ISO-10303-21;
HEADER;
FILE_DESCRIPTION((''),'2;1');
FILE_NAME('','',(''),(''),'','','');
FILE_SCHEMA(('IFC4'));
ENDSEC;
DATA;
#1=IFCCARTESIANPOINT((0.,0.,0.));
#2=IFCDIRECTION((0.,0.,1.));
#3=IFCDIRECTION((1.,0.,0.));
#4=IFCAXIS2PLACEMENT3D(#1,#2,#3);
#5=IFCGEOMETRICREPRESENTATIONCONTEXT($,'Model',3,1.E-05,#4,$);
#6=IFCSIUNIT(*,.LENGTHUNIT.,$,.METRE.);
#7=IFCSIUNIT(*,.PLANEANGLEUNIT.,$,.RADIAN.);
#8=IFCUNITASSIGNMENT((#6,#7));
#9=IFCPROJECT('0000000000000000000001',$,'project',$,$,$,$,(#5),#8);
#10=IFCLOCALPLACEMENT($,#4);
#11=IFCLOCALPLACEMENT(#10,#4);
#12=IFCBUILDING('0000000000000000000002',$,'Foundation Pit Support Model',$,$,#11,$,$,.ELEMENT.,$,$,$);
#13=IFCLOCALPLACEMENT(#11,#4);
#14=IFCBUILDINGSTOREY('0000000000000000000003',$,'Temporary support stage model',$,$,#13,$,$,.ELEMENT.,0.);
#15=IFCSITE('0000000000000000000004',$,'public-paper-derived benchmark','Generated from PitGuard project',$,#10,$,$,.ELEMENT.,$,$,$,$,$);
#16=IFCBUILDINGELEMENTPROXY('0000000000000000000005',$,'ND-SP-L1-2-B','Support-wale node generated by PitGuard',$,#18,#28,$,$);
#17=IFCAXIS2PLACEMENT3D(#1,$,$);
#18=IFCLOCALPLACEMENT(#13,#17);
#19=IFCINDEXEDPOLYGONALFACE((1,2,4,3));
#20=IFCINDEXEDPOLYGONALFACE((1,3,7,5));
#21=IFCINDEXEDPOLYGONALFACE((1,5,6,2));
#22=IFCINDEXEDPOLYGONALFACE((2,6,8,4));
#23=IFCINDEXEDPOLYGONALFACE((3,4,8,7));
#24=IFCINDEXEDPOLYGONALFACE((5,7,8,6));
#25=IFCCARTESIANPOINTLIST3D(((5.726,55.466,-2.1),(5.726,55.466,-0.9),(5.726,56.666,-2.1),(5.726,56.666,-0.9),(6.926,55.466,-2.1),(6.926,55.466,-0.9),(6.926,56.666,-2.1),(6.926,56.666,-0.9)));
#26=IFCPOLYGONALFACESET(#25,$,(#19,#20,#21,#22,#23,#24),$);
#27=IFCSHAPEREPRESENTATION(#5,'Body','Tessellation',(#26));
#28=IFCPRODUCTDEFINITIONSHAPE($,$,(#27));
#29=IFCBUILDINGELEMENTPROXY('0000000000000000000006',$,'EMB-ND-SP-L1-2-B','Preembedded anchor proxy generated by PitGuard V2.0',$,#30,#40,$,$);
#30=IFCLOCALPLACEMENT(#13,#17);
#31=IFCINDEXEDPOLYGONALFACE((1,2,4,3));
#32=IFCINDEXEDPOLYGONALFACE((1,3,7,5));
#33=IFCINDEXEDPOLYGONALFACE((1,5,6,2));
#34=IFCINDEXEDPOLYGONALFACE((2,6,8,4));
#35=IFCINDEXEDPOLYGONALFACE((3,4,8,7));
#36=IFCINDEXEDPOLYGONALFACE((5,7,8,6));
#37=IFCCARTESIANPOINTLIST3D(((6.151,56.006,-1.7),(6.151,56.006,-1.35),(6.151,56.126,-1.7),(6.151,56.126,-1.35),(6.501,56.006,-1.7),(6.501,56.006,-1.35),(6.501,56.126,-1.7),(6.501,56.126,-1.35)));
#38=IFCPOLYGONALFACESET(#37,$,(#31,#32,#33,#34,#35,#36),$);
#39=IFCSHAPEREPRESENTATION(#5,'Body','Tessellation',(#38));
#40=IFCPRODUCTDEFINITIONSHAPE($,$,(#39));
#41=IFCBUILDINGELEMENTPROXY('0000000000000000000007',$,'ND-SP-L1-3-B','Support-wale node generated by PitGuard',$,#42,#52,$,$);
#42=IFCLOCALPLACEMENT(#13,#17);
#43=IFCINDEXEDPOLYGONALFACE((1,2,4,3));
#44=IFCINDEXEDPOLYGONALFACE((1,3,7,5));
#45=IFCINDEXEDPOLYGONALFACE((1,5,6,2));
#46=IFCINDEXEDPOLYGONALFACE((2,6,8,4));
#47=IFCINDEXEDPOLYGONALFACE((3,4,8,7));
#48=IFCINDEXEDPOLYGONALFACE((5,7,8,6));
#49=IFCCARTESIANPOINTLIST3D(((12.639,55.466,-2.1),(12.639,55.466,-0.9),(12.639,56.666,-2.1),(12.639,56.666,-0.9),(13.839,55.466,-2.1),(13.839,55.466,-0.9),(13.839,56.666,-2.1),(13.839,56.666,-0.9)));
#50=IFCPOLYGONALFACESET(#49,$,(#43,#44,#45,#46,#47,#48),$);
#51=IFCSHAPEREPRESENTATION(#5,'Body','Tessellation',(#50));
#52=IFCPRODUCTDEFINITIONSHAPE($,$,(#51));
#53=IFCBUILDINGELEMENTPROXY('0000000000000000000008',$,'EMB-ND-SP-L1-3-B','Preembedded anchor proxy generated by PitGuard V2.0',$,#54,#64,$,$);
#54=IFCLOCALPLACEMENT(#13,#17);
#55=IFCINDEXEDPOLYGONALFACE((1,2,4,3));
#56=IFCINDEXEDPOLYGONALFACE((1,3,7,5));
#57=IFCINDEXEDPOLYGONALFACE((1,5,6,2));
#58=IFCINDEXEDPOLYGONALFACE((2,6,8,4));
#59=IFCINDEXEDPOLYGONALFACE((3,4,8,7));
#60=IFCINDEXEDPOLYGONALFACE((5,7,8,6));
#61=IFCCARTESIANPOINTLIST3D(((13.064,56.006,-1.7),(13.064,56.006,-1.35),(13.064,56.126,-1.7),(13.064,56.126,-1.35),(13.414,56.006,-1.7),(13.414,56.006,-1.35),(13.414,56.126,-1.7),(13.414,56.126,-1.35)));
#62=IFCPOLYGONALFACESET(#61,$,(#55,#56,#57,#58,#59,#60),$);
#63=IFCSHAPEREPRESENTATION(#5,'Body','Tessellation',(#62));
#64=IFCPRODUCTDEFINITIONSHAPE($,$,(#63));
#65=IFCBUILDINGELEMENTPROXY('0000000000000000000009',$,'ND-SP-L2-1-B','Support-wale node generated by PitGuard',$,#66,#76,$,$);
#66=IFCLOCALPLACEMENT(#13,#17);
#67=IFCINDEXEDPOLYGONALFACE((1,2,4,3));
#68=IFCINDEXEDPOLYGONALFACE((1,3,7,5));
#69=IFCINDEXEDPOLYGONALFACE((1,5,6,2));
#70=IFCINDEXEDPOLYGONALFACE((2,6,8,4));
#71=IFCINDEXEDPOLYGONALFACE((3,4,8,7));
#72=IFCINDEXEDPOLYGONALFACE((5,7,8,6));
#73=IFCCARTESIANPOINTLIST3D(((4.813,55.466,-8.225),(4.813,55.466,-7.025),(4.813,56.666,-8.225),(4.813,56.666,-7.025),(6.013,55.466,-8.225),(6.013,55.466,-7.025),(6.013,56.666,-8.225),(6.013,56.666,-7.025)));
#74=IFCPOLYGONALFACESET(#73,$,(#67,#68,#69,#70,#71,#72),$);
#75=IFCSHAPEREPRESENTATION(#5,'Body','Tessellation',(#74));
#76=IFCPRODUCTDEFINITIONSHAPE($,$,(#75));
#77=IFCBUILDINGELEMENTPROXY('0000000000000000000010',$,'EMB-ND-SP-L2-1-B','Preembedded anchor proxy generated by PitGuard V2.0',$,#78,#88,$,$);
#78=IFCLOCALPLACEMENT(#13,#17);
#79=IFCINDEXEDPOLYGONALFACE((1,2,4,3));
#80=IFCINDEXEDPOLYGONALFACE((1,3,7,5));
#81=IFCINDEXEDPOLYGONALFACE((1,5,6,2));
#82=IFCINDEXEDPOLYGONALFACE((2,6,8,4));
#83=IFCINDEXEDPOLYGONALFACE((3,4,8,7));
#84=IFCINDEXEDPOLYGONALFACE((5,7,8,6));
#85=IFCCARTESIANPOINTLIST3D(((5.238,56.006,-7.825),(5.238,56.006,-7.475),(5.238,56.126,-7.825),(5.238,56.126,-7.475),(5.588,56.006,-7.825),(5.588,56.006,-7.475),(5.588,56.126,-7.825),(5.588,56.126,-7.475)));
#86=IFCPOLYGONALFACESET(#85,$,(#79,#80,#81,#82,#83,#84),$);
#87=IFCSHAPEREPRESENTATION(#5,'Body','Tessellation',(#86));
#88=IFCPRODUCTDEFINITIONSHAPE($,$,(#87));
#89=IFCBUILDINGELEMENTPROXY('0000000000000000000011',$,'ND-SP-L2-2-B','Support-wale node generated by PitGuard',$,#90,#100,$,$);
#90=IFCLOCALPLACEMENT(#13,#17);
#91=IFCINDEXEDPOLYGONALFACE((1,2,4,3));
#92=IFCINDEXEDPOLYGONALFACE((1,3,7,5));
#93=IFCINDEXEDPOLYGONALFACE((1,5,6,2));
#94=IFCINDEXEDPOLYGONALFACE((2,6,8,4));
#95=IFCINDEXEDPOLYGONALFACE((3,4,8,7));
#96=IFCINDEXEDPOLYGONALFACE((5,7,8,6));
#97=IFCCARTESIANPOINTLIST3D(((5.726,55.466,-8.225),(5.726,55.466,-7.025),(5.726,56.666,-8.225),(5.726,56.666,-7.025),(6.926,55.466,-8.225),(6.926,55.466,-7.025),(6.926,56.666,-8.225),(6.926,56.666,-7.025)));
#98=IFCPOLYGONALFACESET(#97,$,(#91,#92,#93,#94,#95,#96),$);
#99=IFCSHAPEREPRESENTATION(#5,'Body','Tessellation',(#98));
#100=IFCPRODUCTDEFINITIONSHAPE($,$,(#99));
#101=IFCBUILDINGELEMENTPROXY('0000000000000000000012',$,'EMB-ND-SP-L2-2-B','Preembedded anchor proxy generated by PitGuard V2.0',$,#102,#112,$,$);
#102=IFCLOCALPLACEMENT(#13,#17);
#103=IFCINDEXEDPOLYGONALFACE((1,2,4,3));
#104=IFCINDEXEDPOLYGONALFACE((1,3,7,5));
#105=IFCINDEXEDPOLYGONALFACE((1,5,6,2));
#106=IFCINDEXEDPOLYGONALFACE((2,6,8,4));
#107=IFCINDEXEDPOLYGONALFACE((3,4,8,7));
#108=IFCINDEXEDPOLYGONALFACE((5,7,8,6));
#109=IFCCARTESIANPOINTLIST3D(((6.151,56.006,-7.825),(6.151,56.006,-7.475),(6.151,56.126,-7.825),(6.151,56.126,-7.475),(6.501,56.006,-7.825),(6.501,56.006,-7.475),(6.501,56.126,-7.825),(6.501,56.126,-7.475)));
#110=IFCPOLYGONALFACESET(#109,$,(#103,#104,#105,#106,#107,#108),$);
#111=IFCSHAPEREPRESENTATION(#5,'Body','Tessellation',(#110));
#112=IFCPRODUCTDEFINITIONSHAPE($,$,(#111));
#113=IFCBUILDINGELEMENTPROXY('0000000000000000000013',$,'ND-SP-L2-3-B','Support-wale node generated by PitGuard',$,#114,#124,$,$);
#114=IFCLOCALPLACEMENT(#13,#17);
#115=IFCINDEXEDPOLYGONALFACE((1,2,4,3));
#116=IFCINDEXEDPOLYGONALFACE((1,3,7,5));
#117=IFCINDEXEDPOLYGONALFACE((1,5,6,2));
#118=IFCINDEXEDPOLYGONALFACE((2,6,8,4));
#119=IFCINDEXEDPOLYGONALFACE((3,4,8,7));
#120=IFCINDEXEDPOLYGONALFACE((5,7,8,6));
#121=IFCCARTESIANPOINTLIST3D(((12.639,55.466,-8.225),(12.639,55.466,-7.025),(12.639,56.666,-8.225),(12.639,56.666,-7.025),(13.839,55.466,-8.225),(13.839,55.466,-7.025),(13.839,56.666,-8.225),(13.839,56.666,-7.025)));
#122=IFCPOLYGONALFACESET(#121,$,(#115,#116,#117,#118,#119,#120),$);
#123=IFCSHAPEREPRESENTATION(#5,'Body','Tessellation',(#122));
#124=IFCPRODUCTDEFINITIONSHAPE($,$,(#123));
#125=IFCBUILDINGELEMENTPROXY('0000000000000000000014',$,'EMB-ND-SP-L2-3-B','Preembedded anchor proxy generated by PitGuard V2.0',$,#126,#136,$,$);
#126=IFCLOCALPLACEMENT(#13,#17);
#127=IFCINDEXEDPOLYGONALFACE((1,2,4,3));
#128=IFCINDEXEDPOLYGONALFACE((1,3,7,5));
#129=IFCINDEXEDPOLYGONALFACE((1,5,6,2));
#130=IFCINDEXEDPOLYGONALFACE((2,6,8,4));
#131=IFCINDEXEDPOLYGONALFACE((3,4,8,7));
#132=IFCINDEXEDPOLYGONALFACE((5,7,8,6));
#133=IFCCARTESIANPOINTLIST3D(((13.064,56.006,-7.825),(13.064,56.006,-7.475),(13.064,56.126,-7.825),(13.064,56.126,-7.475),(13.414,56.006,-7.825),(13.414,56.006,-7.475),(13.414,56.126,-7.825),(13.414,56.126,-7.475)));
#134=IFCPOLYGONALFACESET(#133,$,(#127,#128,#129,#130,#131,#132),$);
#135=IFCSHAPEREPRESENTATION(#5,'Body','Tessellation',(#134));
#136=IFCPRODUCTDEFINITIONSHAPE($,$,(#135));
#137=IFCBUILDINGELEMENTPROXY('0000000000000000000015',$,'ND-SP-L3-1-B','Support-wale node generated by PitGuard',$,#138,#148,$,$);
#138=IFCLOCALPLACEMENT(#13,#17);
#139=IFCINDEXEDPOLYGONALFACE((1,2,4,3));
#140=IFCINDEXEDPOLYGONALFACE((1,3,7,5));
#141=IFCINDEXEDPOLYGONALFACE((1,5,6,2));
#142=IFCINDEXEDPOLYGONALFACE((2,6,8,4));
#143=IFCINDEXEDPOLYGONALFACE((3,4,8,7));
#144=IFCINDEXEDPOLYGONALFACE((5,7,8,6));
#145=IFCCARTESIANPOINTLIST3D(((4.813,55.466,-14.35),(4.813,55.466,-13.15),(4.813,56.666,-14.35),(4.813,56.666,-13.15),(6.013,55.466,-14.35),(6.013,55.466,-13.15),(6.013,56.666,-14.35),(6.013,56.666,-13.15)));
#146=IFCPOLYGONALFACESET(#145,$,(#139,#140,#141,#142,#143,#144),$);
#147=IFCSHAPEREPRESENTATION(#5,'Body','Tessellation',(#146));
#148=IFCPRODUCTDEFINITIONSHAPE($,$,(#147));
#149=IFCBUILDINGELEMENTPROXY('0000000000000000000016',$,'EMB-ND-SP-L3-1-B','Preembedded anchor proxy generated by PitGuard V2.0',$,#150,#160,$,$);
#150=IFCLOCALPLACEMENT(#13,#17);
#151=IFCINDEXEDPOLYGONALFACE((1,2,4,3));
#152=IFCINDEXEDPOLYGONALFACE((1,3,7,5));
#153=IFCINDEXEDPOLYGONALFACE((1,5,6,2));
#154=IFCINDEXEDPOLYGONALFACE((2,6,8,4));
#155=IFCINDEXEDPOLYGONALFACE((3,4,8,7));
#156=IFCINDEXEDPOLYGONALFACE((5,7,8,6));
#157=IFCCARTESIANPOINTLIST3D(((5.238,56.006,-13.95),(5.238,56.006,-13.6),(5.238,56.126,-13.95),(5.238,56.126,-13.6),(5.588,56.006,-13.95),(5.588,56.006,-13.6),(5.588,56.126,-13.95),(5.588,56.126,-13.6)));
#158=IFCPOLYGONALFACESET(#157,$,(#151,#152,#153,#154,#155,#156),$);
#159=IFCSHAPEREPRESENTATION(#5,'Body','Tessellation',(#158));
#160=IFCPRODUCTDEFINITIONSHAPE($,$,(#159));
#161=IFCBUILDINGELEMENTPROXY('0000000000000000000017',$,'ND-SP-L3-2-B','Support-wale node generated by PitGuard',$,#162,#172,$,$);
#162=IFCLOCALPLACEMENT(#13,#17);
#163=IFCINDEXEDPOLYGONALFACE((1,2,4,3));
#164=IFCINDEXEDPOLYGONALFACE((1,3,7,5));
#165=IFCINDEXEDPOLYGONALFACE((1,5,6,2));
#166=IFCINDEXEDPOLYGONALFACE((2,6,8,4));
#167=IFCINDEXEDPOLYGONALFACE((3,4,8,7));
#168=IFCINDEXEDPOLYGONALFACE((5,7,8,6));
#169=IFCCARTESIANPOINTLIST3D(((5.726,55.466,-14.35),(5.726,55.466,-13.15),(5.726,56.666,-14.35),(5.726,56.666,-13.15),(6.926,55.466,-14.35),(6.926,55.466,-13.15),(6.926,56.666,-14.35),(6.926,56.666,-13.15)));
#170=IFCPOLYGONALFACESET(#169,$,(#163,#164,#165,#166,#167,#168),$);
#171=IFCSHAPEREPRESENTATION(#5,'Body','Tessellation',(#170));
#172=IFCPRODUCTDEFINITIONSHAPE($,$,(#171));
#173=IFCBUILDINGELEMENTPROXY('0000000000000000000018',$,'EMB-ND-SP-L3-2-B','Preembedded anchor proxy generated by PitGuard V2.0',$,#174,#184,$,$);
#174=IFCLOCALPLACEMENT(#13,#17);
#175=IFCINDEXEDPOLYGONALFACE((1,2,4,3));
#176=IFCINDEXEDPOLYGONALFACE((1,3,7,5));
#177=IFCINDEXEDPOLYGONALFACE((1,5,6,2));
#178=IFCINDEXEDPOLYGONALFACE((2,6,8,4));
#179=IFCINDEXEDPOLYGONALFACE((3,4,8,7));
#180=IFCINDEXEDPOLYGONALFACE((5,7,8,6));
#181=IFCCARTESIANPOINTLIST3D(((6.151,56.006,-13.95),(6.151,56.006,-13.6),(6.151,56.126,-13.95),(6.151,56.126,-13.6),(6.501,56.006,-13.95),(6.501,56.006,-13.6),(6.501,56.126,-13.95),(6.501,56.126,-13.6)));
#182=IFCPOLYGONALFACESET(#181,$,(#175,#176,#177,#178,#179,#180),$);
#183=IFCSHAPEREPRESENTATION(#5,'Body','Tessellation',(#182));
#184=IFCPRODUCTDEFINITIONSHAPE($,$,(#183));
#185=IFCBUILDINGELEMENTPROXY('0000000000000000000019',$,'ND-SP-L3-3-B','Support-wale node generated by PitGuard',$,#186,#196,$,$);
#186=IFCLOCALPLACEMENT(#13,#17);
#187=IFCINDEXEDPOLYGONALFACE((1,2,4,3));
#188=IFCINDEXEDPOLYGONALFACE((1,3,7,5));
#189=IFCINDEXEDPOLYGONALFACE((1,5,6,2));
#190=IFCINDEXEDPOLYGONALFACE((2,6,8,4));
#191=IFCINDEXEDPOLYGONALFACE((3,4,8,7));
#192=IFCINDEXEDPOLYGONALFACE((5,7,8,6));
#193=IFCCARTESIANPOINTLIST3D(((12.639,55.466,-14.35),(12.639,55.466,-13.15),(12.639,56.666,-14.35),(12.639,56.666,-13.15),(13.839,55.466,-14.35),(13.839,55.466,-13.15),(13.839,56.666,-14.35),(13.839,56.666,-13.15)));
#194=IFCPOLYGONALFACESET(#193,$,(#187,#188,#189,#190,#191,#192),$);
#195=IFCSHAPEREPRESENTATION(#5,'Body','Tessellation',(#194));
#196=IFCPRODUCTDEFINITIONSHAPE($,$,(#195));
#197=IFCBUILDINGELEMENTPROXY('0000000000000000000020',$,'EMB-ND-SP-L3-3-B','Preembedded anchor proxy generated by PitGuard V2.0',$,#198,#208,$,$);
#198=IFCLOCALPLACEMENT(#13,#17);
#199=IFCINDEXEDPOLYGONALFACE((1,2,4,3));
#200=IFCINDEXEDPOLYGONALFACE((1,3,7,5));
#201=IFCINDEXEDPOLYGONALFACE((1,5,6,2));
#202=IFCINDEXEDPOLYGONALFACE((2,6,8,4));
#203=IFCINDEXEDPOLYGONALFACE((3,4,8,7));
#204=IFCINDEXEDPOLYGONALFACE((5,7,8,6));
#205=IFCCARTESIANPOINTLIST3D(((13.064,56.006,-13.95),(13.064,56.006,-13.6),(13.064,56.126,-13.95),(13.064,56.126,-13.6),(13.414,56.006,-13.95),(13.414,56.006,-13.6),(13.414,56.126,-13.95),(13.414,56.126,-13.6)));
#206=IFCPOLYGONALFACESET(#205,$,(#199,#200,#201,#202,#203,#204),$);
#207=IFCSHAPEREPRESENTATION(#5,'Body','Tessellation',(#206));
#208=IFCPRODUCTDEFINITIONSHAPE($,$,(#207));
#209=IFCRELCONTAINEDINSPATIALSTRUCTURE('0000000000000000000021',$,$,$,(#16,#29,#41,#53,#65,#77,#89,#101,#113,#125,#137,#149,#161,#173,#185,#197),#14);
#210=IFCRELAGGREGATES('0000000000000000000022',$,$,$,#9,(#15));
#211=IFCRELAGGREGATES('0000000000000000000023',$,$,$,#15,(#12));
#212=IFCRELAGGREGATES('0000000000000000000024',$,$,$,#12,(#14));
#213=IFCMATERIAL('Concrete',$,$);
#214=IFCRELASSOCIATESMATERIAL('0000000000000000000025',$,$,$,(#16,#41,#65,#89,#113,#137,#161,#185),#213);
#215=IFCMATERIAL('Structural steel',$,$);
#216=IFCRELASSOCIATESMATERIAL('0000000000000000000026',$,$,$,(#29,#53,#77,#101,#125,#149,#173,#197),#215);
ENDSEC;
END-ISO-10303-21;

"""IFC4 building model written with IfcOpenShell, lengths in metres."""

from ifc_helpers import new_model, si_unit, frame, origin_with_axes, origin_2d, place, context, project, spatial, rectangle, extrude, material, element, save


model = new_model("IFC4")

# Units and contexts
model_context = context("Model", 3, precision=1e-05, world=origin_with_axes())
ifc_project = project(units=[si_unit("LENGTHUNIT", "METRE"), si_unit("PLANEANGLEUNIT", "RADIAN")], contexts=[model_context])

# Site, building, storey
site_placement = place(None, origin_with_axes())
site = spatial("IfcSite", under=ifc_project, at=site_placement, Name="public-paper-derived benchmark", Description="Generated from PitGuard project", CompositionType="ELEMENT")
building_placement = place(site_placement, origin_with_axes())
building = spatial("IfcBuilding", under=site, at=building_placement, Name="Foundation Pit Support Model", CompositionType="ELEMENT")
storey_placement = place(building_placement, origin_with_axes())
storey = spatial("IfcBuildingStorey", under=building, at=storey_placement, Name="Temporary support stage model", CompositionType="ELEMENT", Elevation=0.0)

# Shared definitions
ifc_material_1 = material(Name="Concrete")

# Shared definitions
ifc_material_2 = material(Name="Structural steel")

# Building element proxies
proxy_1_placement = place(storey_placement, frame((6.326, 56.066, -2.1), z_axis=(0.0, 0.0, 1.0), x_axis=(1.0, 0.0, 0.0)))
element("IfcBuildingElementProxy", 1, at=proxy_1_placement, inside=storey, material=ifc_material_1, Name="ND-SP-L1-2-B", Description="Support-wale node generated by PitGuard", context=model_context, shape_type="SweptSolid", body=[
    extrude(rectangle(XDim=1.2, YDim=1.2, at=origin_2d()), origin_with_axes(), (0.0, 0.0, 1.0), 1.2),
])
proxy_2_placement = place(storey_placement, frame((6.326, 56.066, -1.7), z_axis=(0.0, 0.0, 1.0), x_axis=(1.0, 0.0, 0.0)))
element("IfcBuildingElementProxy", 2, at=proxy_2_placement, inside=storey, material=ifc_material_2, Name="EMB-ND-SP-L1-2-B", Description="Preembedded anchor proxy generated by PitGuard V2.0", context=model_context, shape_type="SweptSolid", body=[
    extrude(rectangle(XDim=0.35, YDim=0.12, at=origin_2d()), origin_with_axes(), (0.0, 0.0, 1.0), 0.35),
])
proxy_3_placement = place(storey_placement, frame((13.239, 56.066, -2.1), z_axis=(0.0, 0.0, 1.0), x_axis=(1.0, 0.0, 0.0)))
element("IfcBuildingElementProxy", 3, at=proxy_3_placement, inside=storey, material=ifc_material_1, Name="ND-SP-L1-3-B", Description="Support-wale node generated by PitGuard", context=model_context, shape_type="SweptSolid", body=[
    extrude(rectangle(XDim=1.2, YDim=1.2, at=origin_2d()), origin_with_axes(), (0.0, 0.0, 1.0), 1.2),
])
proxy_4_placement = place(storey_placement, frame((13.239, 56.066, -1.7), z_axis=(0.0, 0.0, 1.0), x_axis=(1.0, 0.0, 0.0)))
element("IfcBuildingElementProxy", 4, at=proxy_4_placement, inside=storey, material=ifc_material_2, Name="EMB-ND-SP-L1-3-B", Description="Preembedded anchor proxy generated by PitGuard V2.0", context=model_context, shape_type="SweptSolid", body=[
    extrude(rectangle(XDim=0.35, YDim=0.12, at=origin_2d()), origin_with_axes(), (0.0, 0.0, 1.0), 0.35),
])
proxy_5_placement = place(storey_placement, frame((5.413, 56.066, -8.225), z_axis=(0.0, 0.0, 1.0), x_axis=(1.0, 0.0, 0.0)))
element("IfcBuildingElementProxy", 5, at=proxy_5_placement, inside=storey, material=ifc_material_1, Name="ND-SP-L2-1-B", Description="Support-wale node generated by PitGuard", context=model_context, shape_type="SweptSolid", body=[
    extrude(rectangle(XDim=1.2, YDim=1.2, at=origin_2d()), origin_with_axes(), (0.0, 0.0, 1.0), 1.2),
])
proxy_6_placement = place(storey_placement, frame((5.413, 56.066, -7.825), z_axis=(0.0, 0.0, 1.0), x_axis=(1.0, 0.0, 0.0)))
element("IfcBuildingElementProxy", 6, at=proxy_6_placement, inside=storey, material=ifc_material_2, Name="EMB-ND-SP-L2-1-B", Description="Preembedded anchor proxy generated by PitGuard V2.0", context=model_context, shape_type="SweptSolid", body=[
    extrude(rectangle(XDim=0.35, YDim=0.12, at=origin_2d()), origin_with_axes(), (0.0, 0.0, 1.0), 0.35),
])
proxy_7_placement = place(storey_placement, frame((6.326, 56.066, -8.225), z_axis=(0.0, 0.0, 1.0), x_axis=(1.0, 0.0, 0.0)))
element("IfcBuildingElementProxy", 7, at=proxy_7_placement, inside=storey, material=ifc_material_1, Name="ND-SP-L2-2-B", Description="Support-wale node generated by PitGuard", context=model_context, shape_type="SweptSolid", body=[
    extrude(rectangle(XDim=1.2, YDim=1.2, at=origin_2d()), origin_with_axes(), (0.0, 0.0, 1.0), 1.2),
])
proxy_8_placement = place(storey_placement, frame((6.326, 56.066, -7.825), z_axis=(0.0, 0.0, 1.0), x_axis=(1.0, 0.0, 0.0)))
element("IfcBuildingElementProxy", 8, at=proxy_8_placement, inside=storey, material=ifc_material_2, Name="EMB-ND-SP-L2-2-B", Description="Preembedded anchor proxy generated by PitGuard V2.0", context=model_context, shape_type="SweptSolid", body=[
    extrude(rectangle(XDim=0.35, YDim=0.12, at=origin_2d()), origin_with_axes(), (0.0, 0.0, 1.0), 0.35),
])
proxy_9_placement = place(storey_placement, frame((13.239, 56.066, -8.225), z_axis=(0.0, 0.0, 1.0), x_axis=(1.0, 0.0, 0.0)))
element("IfcBuildingElementProxy", 9, at=proxy_9_placement, inside=storey, material=ifc_material_1, Name="ND-SP-L2-3-B", Description="Support-wale node generated by PitGuard", context=model_context, shape_type="SweptSolid", body=[
    extrude(rectangle(XDim=1.2, YDim=1.2, at=origin_2d()), origin_with_axes(), (0.0, 0.0, 1.0), 1.2),
])
proxy_10_placement = place(storey_placement, frame((13.239, 56.066, -7.825), z_axis=(0.0, 0.0, 1.0), x_axis=(1.0, 0.0, 0.0)))
element("IfcBuildingElementProxy", 10, at=proxy_10_placement, inside=storey, material=ifc_material_2, Name="EMB-ND-SP-L2-3-B", Description="Preembedded anchor proxy generated by PitGuard V2.0", context=model_context, shape_type="SweptSolid", body=[
    extrude(rectangle(XDim=0.35, YDim=0.12, at=origin_2d()), origin_with_axes(), (0.0, 0.0, 1.0), 0.35),
])
proxy_11_placement = place(storey_placement, frame((5.413, 56.066, -14.35), z_axis=(0.0, 0.0, 1.0), x_axis=(1.0, 0.0, 0.0)))
element("IfcBuildingElementProxy", 11, at=proxy_11_placement, inside=storey, material=ifc_material_1, Name="ND-SP-L3-1-B", Description="Support-wale node generated by PitGuard", context=model_context, shape_type="SweptSolid", body=[
    extrude(rectangle(XDim=1.2, YDim=1.2, at=origin_2d()), origin_with_axes(), (0.0, 0.0, 1.0), 1.2),
])
proxy_12_placement = place(storey_placement, frame((5.413, 56.066, -13.95), z_axis=(0.0, 0.0, 1.0), x_axis=(1.0, 0.0, 0.0)))
element("IfcBuildingElementProxy", 12, at=proxy_12_placement, inside=storey, material=ifc_material_2, Name="EMB-ND-SP-L3-1-B", Description="Preembedded anchor proxy generated by PitGuard V2.0", context=model_context, shape_type="SweptSolid", body=[
    extrude(rectangle(XDim=0.35, YDim=0.12, at=origin_2d()), origin_with_axes(), (0.0, 0.0, 1.0), 0.35),
])
proxy_13_placement = place(storey_placement, frame((6.326, 56.066, -14.35), z_axis=(0.0, 0.0, 1.0), x_axis=(1.0, 0.0, 0.0)))
element("IfcBuildingElementProxy", 13, at=proxy_13_placement, inside=storey, material=ifc_material_1, Name="ND-SP-L3-2-B", Description="Support-wale node generated by PitGuard", context=model_context, shape_type="SweptSolid", body=[
    extrude(rectangle(XDim=1.2, YDim=1.2, at=origin_2d()), origin_with_axes(), (0.0, 0.0, 1.0), 1.2),
])
proxy_14_placement = place(storey_placement, frame((6.326, 56.066, -13.95), z_axis=(0.0, 0.0, 1.0), x_axis=(1.0, 0.0, 0.0)))
element("IfcBuildingElementProxy", 14, at=proxy_14_placement, inside=storey, material=ifc_material_2, Name="EMB-ND-SP-L3-2-B", Description="Preembedded anchor proxy generated by PitGuard V2.0", context=model_context, shape_type="SweptSolid", body=[
    extrude(rectangle(XDim=0.35, YDim=0.12, at=origin_2d()), origin_with_axes(), (0.0, 0.0, 1.0), 0.35),
])
proxy_15_placement = place(storey_placement, frame((13.239, 56.066, -14.35), z_axis=(0.0, 0.0, 1.0), x_axis=(1.0, 0.0, 0.0)))
element("IfcBuildingElementProxy", 15, at=proxy_15_placement, inside=storey, material=ifc_material_1, Name="ND-SP-L3-3-B", Description="Support-wale node generated by PitGuard", context=model_context, shape_type="SweptSolid", body=[
    extrude(rectangle(XDim=1.2, YDim=1.2, at=origin_2d()), origin_with_axes(), (0.0, 0.0, 1.0), 1.2),
])
proxy_16_placement = place(storey_placement, frame((13.239, 56.066, -13.95), z_axis=(0.0, 0.0, 1.0), x_axis=(1.0, 0.0, 0.0)))
element("IfcBuildingElementProxy", 16, at=proxy_16_placement, inside=storey, material=ifc_material_2, Name="EMB-ND-SP-L3-3-B", Description="Preembedded anchor proxy generated by PitGuard V2.0", context=model_context, shape_type="SweptSolid", body=[
    extrude(rectangle(XDim=0.35, YDim=0.12, at=origin_2d()), origin_with_axes(), (0.0, 0.0, 1.0), 0.35),
])

save(model, "model.ifc")
